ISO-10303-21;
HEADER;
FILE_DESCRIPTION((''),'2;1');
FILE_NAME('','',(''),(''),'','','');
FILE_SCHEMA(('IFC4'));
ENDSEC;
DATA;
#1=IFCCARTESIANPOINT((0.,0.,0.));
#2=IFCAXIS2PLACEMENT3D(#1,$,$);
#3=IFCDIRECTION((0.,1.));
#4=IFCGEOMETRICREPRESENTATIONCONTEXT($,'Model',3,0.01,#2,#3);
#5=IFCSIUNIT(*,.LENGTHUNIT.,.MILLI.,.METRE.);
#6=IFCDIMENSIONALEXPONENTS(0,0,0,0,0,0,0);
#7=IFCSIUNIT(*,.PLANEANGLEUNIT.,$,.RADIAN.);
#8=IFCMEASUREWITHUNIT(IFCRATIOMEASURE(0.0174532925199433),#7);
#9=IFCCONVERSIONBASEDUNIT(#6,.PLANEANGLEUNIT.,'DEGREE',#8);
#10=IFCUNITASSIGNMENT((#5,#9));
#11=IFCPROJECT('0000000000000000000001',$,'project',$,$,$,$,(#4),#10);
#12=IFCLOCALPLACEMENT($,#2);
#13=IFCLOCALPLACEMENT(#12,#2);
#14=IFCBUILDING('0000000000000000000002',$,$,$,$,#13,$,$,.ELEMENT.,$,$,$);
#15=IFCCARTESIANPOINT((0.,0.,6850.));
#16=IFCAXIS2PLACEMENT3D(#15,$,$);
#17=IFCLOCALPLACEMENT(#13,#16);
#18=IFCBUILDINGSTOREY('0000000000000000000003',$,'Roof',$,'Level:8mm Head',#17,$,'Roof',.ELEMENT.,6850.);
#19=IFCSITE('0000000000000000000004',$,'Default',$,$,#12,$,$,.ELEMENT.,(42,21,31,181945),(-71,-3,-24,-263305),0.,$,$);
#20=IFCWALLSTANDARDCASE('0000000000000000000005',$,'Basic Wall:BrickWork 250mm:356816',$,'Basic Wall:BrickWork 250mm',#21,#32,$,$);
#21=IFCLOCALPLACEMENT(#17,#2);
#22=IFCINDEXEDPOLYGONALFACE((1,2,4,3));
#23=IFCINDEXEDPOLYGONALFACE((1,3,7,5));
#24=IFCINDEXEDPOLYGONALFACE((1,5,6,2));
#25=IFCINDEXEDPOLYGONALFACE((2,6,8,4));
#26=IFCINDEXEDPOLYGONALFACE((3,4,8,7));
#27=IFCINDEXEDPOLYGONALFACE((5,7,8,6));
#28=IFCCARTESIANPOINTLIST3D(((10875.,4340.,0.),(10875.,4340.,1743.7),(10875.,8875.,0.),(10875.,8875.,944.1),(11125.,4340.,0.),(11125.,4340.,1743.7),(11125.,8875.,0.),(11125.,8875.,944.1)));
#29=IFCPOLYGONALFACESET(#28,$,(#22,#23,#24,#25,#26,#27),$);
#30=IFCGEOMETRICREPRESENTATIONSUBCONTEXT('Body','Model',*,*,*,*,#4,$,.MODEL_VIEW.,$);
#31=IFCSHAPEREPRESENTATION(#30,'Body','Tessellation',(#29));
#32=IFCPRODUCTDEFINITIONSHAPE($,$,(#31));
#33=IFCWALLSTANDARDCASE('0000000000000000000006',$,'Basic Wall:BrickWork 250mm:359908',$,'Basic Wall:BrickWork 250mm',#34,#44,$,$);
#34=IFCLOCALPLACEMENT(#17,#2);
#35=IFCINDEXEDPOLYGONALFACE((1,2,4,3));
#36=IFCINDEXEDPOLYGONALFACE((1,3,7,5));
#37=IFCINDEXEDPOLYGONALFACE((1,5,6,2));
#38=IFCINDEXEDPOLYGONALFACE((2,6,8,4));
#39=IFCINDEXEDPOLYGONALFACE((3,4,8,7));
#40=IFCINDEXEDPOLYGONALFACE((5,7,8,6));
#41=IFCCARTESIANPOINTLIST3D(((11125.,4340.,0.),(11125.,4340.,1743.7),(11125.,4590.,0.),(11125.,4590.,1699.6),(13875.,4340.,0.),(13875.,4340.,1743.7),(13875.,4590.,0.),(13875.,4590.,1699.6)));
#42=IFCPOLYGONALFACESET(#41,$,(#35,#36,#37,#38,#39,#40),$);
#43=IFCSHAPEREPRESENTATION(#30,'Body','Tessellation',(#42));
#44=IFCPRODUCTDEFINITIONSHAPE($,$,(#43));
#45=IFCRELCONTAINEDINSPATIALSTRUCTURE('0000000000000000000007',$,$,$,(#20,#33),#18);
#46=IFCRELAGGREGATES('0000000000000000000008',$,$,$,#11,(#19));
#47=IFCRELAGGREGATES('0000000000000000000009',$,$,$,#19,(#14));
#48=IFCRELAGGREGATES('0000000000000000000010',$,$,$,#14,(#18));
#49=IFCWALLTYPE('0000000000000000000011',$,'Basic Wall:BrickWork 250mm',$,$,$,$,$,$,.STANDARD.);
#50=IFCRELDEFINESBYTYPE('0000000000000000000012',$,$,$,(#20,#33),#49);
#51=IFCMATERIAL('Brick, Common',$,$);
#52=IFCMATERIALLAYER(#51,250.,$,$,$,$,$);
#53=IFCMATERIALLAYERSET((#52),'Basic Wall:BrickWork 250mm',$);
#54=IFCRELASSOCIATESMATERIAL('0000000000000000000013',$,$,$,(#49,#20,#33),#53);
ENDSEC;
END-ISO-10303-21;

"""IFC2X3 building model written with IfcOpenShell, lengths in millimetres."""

from ifc_helpers import new_model, entity, si_unit, converted_unit, direction, frame, frame_2d, origin, place, context, subcontext, project, spatial, polyline, rectangle, extrude, clip, bounded_halfspace, material, layer, layer_set, layer_usage, type_object, element, save


model = new_model("IFC2X3")

# Units and contexts
model_context = context("Model", 3, precision=0.01, world=origin(), true_north=direction((0.0, 1.0)))
body_context = subcontext(model_context, "Body", "Model", "MODEL_VIEW")
ifc_project = project(units=[si_unit("LENGTHUNIT", "METRE", prefix="MILLI"), converted_unit("PLANEANGLEUNIT", "DEGREE", entity("IfcRatioMeasure", 0.0174532925199433), si_unit("PLANEANGLEUNIT", "RADIAN"), dimensions=[0, 0, 0, 0, 0, 0, 0])], contexts=[model_context])

# Site, building, storey
site_placement = place(None, origin())
site = spatial("IfcSite", under=ifc_project, at=site_placement, Name="Default", CompositionType="ELEMENT", RefLatitude=(42, 21, 31, 181945), RefLongitude=(-71, -3, -24, -263305), RefElevation=0.0)
building_placement = place(site_placement, origin())
building = spatial("IfcBuilding", under=site, at=building_placement, CompositionType="ELEMENT")
storey_placement = place(building_placement, frame((0.0, 0.0, 6850.0)))
storey = spatial("IfcBuildingStorey", under=building, at=storey_placement, Name="Roof", ObjectType="Level:8mm Head", LongName="Roof", CompositionType="ELEMENT", Elevation=6850.0)

# Walls
ifc_material = material(Name="Brick, Common")
ifc_layer = layer(ifc_material, 250.0)
ifc_layer_set = layer_set([ifc_layer], Name="Basic Wall:BrickWork 250mm")
ifc_layer_usage_1 = layer_usage(ifc_layer_set, "AXIS2", "POSITIVE", -125.0)
wall_type = type_object("IfcWallType", Name="Basic Wall:BrickWork 250mm", PredefinedType="STANDARD", material=ifc_layer_set)
wall_1_placement = place(storey_placement, frame((11000.0, 8875.0, 0.0), z_axis=(0.0, 0.0, 1.0), x_axis=(0.0, -1.0, 0.0)))
element("IfcWallStandardCase", 1, at=wall_1_placement, inside=storey, type_object=wall_type, material=ifc_layer_usage_1, Name="Basic Wall:BrickWork 250mm:356816", ObjectType="Basic Wall:BrickWork 250mm", context=body_context, shape_type="Clipping", body=[
    clip(extrude(rectangle(XDim=4535.0, YDim=250.0, at=frame_2d((2267.5, 0.0), x_axis=(-1.0, 0.0))), origin(), (0.0, 0.0, 1.0), 1743.7), bounded_halfspace(frame((0.0, -125.0, 944.1), z_axis=(-0.173648, 0.0, 0.984808), x_axis=(0.0, -1.0, 0.0)), False, frame((0.0, -125.0, 944.1)), polyline([(0.0, 0.0), (4535.0, 0.0), (4535.0, 250.0), (4285.0, 250.0), (0.0, 250.0), (0.0, 0.0)]))),
])
ifc_layer_usage_2 = layer_usage(ifc_layer_set, "AXIS2", "POSITIVE", -125.0)
wall_2_placement = place(storey_placement, frame((11125.0, 4465.0, 0.0)))
element("IfcWallStandardCase", 2, at=wall_2_placement, inside=storey, type_object=wall_type, material=ifc_layer_usage_2, Name="Basic Wall:BrickWork 250mm:359908", ObjectType="Basic Wall:BrickWork 250mm", context=body_context, shape_type="Clipping", body=[
    clip(extrude(rectangle(XDim=2750.0, YDim=250.0, at=frame_2d((1375.0, 0.0), x_axis=(-1.0, 0.0))), origin(), (0.0, 0.0, 1.0), 1743.7), bounded_halfspace(frame((0.0, -125.0, 1743.7), z_axis=(0.0, 0.173648, 0.984808), x_axis=(-1.0, 0.0, 0.0)), False, frame((0.0, -125.0, 1743.7)), polyline([(0.0, 0.0), (2750.0, 0.0), (2750.0, 250.0), (0.0, 250.0), (0.0, 0.0)]))),
])

save(model, "model.ifc")
